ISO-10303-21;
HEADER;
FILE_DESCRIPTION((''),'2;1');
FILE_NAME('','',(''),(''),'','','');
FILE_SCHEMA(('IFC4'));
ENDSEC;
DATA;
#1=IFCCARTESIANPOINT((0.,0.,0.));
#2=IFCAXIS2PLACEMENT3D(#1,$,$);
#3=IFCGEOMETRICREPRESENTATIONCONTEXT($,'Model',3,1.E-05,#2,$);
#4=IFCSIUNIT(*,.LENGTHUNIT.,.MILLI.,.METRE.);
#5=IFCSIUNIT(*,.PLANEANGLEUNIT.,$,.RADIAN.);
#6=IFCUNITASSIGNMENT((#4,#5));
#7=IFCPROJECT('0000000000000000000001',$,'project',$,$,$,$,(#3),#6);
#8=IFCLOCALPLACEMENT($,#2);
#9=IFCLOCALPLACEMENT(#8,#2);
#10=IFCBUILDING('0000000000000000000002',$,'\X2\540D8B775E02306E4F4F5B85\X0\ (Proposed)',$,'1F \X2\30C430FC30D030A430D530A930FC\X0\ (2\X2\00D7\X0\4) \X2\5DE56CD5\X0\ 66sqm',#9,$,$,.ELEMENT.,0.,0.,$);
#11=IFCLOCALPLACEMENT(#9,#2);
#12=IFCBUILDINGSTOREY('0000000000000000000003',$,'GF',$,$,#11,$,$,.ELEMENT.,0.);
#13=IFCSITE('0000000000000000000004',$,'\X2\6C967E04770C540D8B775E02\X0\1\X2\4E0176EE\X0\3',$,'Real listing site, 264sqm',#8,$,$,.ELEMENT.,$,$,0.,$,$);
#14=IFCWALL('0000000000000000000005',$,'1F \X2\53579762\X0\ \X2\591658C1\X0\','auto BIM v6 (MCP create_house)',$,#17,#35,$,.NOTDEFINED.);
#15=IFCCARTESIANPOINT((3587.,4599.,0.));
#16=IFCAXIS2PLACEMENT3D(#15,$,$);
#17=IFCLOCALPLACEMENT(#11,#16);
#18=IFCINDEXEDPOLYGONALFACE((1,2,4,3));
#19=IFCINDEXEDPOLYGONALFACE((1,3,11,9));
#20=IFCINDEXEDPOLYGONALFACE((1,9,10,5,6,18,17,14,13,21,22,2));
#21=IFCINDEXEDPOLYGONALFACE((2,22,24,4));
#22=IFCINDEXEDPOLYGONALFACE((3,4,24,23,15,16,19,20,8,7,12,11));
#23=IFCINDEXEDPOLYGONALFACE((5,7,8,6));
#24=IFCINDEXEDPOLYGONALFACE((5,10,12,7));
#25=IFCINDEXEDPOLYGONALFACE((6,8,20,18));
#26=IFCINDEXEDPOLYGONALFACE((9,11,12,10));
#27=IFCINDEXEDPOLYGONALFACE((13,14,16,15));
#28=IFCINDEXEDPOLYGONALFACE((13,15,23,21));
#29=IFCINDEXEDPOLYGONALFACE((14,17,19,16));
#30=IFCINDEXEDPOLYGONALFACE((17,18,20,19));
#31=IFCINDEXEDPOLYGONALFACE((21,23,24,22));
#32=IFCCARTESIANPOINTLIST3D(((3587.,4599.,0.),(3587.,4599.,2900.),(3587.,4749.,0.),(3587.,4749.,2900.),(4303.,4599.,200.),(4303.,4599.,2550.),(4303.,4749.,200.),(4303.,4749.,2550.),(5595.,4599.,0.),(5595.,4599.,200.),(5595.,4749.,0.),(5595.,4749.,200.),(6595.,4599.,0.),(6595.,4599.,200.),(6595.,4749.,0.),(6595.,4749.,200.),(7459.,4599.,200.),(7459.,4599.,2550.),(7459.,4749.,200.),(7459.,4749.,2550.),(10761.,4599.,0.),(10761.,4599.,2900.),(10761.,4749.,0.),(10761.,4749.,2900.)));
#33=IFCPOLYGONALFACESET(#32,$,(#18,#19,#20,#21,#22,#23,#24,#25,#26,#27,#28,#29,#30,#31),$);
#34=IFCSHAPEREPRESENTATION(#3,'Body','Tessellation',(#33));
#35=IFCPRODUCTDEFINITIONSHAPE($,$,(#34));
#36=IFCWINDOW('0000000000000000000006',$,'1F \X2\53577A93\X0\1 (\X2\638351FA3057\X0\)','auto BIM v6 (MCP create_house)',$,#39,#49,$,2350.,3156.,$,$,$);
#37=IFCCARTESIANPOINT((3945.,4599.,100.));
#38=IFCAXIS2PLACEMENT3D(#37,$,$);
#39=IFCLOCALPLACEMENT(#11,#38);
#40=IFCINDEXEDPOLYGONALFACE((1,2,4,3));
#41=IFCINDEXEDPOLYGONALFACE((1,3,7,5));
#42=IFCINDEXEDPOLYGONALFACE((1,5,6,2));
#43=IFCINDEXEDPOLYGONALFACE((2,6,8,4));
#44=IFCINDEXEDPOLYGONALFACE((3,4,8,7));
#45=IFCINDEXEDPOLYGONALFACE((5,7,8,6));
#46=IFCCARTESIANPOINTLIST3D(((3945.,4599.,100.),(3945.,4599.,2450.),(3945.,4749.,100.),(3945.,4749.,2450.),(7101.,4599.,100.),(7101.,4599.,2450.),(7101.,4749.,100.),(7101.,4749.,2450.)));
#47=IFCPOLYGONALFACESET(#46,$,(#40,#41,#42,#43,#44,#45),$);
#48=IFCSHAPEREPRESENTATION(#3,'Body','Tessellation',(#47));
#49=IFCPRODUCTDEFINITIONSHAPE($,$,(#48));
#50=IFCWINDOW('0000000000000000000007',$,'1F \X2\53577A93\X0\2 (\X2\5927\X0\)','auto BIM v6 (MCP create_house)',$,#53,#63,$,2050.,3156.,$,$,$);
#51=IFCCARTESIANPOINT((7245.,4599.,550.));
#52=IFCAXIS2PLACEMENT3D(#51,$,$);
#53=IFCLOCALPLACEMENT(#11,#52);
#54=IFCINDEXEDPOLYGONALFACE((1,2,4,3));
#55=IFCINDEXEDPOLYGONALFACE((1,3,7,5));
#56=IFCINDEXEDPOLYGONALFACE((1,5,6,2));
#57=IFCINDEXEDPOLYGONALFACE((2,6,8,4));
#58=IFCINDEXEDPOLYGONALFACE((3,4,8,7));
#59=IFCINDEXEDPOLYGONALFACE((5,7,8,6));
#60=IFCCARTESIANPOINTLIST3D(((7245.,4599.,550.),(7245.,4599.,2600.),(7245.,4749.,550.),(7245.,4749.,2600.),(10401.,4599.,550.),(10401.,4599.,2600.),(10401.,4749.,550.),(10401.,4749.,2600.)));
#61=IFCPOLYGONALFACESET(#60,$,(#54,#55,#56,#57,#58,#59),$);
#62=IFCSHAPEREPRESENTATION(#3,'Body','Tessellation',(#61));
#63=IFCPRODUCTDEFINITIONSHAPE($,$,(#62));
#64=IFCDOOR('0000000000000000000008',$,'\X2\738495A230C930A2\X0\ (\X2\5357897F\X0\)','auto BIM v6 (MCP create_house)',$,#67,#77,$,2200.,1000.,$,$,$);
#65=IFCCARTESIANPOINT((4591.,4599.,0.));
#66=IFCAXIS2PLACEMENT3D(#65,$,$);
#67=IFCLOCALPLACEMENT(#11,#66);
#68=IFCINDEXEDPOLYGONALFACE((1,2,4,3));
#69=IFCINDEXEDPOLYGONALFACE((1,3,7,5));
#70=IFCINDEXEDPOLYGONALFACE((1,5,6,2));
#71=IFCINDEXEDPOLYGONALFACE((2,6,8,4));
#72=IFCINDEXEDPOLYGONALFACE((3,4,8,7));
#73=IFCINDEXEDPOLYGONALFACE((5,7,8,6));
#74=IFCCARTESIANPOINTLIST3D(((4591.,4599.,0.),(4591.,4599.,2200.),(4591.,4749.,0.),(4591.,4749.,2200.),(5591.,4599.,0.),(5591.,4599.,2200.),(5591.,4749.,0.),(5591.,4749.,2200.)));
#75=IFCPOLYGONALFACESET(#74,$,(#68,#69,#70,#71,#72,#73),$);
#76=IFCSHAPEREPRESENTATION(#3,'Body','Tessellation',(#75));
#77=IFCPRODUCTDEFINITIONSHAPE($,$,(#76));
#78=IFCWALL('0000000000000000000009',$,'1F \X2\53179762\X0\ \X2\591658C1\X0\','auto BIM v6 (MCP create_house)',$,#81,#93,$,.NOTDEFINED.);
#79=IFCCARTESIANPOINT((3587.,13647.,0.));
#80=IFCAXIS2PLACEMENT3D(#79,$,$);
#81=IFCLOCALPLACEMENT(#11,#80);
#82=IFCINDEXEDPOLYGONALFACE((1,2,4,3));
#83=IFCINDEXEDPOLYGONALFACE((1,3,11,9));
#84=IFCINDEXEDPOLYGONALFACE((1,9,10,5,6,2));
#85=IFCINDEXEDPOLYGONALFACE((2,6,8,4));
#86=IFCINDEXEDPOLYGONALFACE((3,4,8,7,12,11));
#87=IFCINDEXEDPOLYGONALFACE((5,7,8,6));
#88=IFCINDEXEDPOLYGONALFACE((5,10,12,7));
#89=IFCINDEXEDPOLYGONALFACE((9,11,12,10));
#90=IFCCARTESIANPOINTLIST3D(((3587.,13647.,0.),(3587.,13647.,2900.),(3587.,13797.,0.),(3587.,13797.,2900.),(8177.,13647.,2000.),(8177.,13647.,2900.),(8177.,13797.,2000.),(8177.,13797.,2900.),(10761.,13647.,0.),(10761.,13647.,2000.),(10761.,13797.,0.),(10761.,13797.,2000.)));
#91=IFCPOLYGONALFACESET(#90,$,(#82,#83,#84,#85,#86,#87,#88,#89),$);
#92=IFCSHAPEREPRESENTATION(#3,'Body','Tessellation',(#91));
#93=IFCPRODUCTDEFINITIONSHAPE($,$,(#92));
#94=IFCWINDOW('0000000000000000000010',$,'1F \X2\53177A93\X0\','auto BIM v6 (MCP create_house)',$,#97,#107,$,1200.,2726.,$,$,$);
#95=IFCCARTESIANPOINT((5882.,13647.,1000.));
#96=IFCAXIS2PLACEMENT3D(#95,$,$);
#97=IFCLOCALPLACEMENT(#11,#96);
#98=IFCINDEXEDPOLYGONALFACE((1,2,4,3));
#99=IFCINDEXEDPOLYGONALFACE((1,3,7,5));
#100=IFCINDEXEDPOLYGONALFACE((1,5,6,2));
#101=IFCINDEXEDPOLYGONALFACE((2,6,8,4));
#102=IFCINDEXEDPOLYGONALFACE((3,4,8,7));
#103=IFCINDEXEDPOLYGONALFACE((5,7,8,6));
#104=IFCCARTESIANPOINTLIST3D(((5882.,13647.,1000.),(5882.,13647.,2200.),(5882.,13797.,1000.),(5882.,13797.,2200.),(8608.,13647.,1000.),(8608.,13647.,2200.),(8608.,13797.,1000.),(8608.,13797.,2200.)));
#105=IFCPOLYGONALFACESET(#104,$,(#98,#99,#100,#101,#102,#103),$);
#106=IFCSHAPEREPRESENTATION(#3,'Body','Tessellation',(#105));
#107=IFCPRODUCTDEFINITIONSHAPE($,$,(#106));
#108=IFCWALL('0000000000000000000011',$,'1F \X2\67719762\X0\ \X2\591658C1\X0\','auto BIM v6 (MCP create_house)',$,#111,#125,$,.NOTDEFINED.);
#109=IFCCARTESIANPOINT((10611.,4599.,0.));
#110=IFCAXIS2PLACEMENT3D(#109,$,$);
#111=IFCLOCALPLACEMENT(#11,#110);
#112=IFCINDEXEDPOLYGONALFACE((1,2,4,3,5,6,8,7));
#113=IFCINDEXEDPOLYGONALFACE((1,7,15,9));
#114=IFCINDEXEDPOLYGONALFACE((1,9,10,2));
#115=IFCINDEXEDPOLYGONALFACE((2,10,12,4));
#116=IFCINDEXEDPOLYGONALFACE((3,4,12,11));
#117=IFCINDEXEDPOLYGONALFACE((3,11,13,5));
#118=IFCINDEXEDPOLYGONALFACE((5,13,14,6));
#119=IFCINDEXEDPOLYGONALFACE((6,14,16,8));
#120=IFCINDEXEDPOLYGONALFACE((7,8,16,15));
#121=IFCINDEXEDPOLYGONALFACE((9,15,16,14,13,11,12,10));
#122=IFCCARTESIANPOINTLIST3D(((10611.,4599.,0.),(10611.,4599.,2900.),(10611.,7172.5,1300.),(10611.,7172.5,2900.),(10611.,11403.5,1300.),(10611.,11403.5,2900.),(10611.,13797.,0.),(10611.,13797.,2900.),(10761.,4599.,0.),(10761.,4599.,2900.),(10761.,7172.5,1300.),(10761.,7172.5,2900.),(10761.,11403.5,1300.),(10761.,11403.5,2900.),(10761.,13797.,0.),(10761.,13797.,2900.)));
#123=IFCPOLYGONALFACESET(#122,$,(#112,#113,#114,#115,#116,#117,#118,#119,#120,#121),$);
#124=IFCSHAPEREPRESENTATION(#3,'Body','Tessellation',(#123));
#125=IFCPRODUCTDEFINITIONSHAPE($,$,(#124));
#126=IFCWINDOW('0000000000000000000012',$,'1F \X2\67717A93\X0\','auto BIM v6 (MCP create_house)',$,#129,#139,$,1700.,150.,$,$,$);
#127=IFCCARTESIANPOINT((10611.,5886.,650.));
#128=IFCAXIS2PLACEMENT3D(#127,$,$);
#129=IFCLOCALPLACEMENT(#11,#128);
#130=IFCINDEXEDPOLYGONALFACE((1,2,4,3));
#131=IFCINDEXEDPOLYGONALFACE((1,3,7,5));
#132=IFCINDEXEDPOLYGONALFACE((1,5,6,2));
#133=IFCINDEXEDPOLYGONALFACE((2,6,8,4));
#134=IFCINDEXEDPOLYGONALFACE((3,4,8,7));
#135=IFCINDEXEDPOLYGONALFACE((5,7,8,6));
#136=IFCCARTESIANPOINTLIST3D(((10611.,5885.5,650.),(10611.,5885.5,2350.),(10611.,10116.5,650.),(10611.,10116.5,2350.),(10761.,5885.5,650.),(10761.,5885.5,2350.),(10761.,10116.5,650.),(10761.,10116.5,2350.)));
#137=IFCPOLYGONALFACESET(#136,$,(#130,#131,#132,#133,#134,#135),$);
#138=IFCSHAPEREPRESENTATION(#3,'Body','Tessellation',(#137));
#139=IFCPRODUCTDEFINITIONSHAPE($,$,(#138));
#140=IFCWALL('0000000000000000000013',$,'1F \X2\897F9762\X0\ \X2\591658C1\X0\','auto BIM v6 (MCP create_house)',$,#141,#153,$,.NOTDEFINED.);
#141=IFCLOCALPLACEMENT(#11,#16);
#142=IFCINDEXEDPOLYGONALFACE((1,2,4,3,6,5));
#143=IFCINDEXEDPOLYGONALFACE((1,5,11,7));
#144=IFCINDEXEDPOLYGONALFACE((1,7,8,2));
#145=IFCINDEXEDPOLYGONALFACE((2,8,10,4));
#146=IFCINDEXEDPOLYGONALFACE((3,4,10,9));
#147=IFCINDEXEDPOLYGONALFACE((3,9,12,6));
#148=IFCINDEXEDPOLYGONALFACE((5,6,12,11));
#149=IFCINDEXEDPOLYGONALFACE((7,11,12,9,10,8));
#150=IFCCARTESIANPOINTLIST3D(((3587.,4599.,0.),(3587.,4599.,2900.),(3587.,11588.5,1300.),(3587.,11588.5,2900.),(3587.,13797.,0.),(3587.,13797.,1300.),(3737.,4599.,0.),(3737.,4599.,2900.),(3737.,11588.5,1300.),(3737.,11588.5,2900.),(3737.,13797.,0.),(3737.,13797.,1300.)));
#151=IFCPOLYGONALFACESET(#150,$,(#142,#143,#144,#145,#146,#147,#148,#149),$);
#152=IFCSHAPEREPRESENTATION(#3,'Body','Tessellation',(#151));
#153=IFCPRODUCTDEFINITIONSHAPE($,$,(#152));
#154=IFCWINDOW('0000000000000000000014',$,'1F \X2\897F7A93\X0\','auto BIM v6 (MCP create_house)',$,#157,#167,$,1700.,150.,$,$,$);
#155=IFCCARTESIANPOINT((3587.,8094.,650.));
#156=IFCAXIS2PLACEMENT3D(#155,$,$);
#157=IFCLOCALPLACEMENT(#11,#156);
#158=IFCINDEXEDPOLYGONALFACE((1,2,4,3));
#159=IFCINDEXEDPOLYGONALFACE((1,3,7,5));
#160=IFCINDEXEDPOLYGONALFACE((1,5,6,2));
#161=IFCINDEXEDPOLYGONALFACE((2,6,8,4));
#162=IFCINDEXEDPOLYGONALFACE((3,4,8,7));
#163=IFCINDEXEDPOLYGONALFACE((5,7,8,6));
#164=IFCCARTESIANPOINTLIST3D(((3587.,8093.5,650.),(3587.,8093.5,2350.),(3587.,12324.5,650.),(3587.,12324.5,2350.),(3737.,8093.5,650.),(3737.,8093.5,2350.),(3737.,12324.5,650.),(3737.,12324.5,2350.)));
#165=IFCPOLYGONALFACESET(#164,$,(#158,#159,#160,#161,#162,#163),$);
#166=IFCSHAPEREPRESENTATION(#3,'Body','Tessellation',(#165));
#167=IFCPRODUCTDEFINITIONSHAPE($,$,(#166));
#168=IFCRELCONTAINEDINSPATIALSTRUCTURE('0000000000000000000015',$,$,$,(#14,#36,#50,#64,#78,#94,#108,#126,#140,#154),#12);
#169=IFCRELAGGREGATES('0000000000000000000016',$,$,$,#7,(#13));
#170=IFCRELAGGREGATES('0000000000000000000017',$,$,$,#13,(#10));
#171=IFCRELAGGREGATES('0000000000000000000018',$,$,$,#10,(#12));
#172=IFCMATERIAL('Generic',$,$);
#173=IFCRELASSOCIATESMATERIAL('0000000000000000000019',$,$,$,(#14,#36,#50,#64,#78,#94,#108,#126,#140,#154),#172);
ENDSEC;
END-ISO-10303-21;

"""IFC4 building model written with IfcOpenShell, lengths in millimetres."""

from ifc_helpers import new_model, si_unit, frame, frame_2d, origin, place, context, project, spatial, rectangle, extrude, material, element, fill, save


model = new_model("IFC4")

# Units and contexts
model_context = context("Model", 3, precision=1e-05, world=origin())
ifc_project = project(units=[si_unit("LENGTHUNIT", "METRE", prefix="MILLI"), si_unit("PLANEANGLEUNIT", "RADIAN")], contexts=[model_context])

# Site, building, storey
site_placement = place(None, origin())
site = spatial("IfcSite", under=ifc_project, at=site_placement, Name="沖縄県名護市1丁目3", ObjectType="Real listing site, 264sqm", CompositionType="ELEMENT", RefElevation=0.0)
building_placement = place(site_placement, origin())
building = spatial("IfcBuilding", under=site, at=building_placement, Name="名護市の住宅 (Proposed)", ObjectType="1F ツーバイフォー (2×4) 工法 66sqm", CompositionType="ELEMENT", ElevationOfRefHeight=0.0, ElevationOfTerrain=0.0)
storey_placement = place(building_placement, origin())
storey = spatial("IfcBuildingStorey", under=building, at=storey_placement, Name="GF", CompositionType="ELEMENT", Elevation=0.0)

# Shared definitions
ifc_material = material(Name="Generic")

# Wall, openings, windows, door
wall_1_placement = place(storey_placement, frame((3587.0, 4599.0, 0.0)))
wall_1 = element("IfcWall", 1, at=wall_1_placement, inside=storey, material=ifc_material, Name="1F 南面 外壁", Description="auto BIM v6 (MCP create_house)", PredefinedType="NOTDEFINED", context=model_context, shape_type="SweptSolid", body=[
    extrude(rectangle(XDim=7174.0, YDim=150.0, at=frame_2d((3587.0, 75.0))), frame((3587.0, 4599.0, 0.0)), (0.0, 0.0, 1.0), 2900.0),
])
opening_1_placement = place(storey_placement, frame((3945.0, 4599.0, 100.0)))
opening_1 = element("IfcOpeningElement", 2, at=opening_1_placement, cuts=wall_1, PredefinedType="NOTDEFINED", context=model_context, shape_type="SweptSolid", body=[
    extrude(rectangle(XDim=3156.0, YDim=150.0, at=frame_2d((1578.0, 75.0))), frame((3945.0, 4599.0, 100.0)), (0.0, 0.0, 1.0), 2350.0),
])
opening_2_placement = place(storey_placement, frame((7245.0, 4599.0, 550.0)))
opening_2 = element("IfcOpeningElement", 3, at=opening_2_placement, cuts=wall_1, PredefinedType="NOTDEFINED", context=model_context, shape_type="SweptSolid", body=[
    extrude(rectangle(XDim=3156.0, YDim=150.0, at=frame_2d((1578.0, 75.0))), frame((7245.0, 4599.0, 550.0)), (0.0, 0.0, 1.0), 2050.0),
])
opening_3_placement = place(storey_placement, frame((4591.0, 4599.0, 0.0)))
opening_3 = element("IfcOpeningElement", 4, at=opening_3_placement, cuts=wall_1, PredefinedType="NOTDEFINED", context=model_context, shape_type="SweptSolid", body=[
    extrude(rectangle(XDim=1000.0, YDim=150.0, at=frame_2d((500.0, 75.0))), frame((4591.0, 4599.0, 0.0)), (0.0, 0.0, 1.0), 2200.0),
])
window_1_placement = place(storey_placement, frame((3945.0, 4599.0, 100.0)))
window_1 = element("IfcWindow", 5, at=window_1_placement, inside=storey, material=ifc_material, Name="1F 南窓1 (掃出し)", Description="auto BIM v6 (MCP create_house)", OverallHeight=2350.0, OverallWidth=3156.0, context=model_context, shape_type="SweptSolid", body=[
    extrude(rectangle(XDim=3156.0, YDim=150.0, at=frame_2d((1578.0, 75.0))), frame((3945.0, 4599.0, 100.0)), (0.0, 0.0, 1.0), 2350.0),
])
fill(opening_1, window_1)
window_2_placement = place(storey_placement, frame((7245.0, 4599.0, 550.0)))
window_2 = element("IfcWindow", 6, at=window_2_placement, inside=storey, material=ifc_material, Name="1F 南窓2 (大)", Description="auto BIM v6 (MCP create_house)", OverallHeight=2050.0, OverallWidth=3156.0, context=model_context, shape_type="SweptSolid", body=[
    extrude(rectangle(XDim=3156.0, YDim=150.0, at=frame_2d((1578.0, 75.0))), frame((7245.0, 4599.0, 550.0)), (0.0, 0.0, 1.0), 2050.0),
])
fill(opening_2, window_2)
door_placement = place(storey_placement, frame((4591.0, 4599.0, 0.0)))
door = element("IfcDoor", 7, at=door_placement, inside=storey, material=ifc_material, Name="玄関ドア (南西)", Description="auto BIM v6 (MCP create_house)", OverallHeight=2200.0, OverallWidth=1000.0, context=model_context, shape_type="SweptSolid", body=[
    extrude(rectangle(XDim=1000.0, YDim=150.0, at=frame_2d((500.0, 75.0))), frame((4591.0, 4599.0, 0.0)), (0.0, 0.0, 1.0), 2200.0),
])
fill(opening_3, door)

# Walls, openings, windows
wall_2_placement = place(storey_placement, frame((3587.0, 13647.0, 0.0)))
wall_2 = element("IfcWall", 8, at=wall_2_placement, inside=storey, material=ifc_material, Name="1F 北面 外壁", Description="auto BIM v6 (MCP create_house)", PredefinedType="NOTDEFINED", context=model_context, shape_type="SweptSolid", body=[
    extrude(rectangle(XDim=7174.0, YDim=150.0, at=frame_2d((3587.0, 75.0))), frame((3587.0, 13647.0, 0.0)), (0.0, 0.0, 1.0), 2900.0),
])
opening_4_placement = place(storey_placement, frame((5882.0, 13647.0, 1000.0)))
opening_4 = element("IfcOpeningElement", 9, at=opening_4_placement, cuts=wall_2, PredefinedType="NOTDEFINED", context=model_context, shape_type="SweptSolid", body=[
    extrude(rectangle(XDim=2726.0, YDim=150.0, at=frame_2d((1363.0, 75.0))), frame((5882.0, 13647.0, 1000.0)), (0.0, 0.0, 1.0), 1200.0),
])
window_3_placement = place(storey_placement, frame((5882.0, 13647.0, 1000.0)))
window_3 = element("IfcWindow", 10, at=window_3_placement, inside=storey, material=ifc_material, Name="1F 北窓", Description="auto BIM v6 (MCP create_house)", OverallHeight=1200.0, OverallWidth=2726.0, context=model_context, shape_type="SweptSolid", body=[
    extrude(rectangle(XDim=2726.0, YDim=150.0, at=frame_2d((1363.0, 75.0))), frame((5882.0, 13647.0, 1000.0)), (0.0, 0.0, 1.0), 1200.0),
])
fill(opening_4, window_3)
wall_3_placement = place(storey_placement, frame((10611.0, 4599.0, 0.0)))
wall_3 = element("IfcWall", 11, at=wall_3_placement, inside=storey, material=ifc_material, Name="1F 東面 外壁", Description="auto BIM v6 (MCP create_house)", PredefinedType="NOTDEFINED", context=model_context, shape_type="SweptSolid", body=[
    extrude(rectangle(XDim=150.0, YDim=9198.0, at=frame_2d((75.0, 4599.0))), frame((10611.0, 4599.0, 0.0)), (0.0, 0.0, 1.0), 2900.0),
])
opening_5_placement = place(storey_placement, frame((10611.0, 5886.0, 650.0)))
opening_5 = element("IfcOpeningElement", 12, at=opening_5_placement, cuts=wall_3, PredefinedType="NOTDEFINED", context=model_context, shape_type="SweptSolid", body=[
    extrude(rectangle(XDim=150.0, YDim=4231.0, at=frame_2d((75.0, 2115.0))), frame((10611.0, 5886.0, 650.0)), (0.0, 0.0, 1.0), 1700.0),
])
window_4_placement = place(storey_placement, frame((10611.0, 5886.0, 650.0)))
window_4 = element("IfcWindow", 13, at=window_4_placement, inside=storey, material=ifc_material, Name="1F 東窓", Description="auto BIM v6 (MCP create_house)", OverallHeight=1700.0, OverallWidth=150.0, context=model_context, shape_type="SweptSolid", body=[
    extrude(rectangle(XDim=150.0, YDim=4231.0, at=frame_2d((75.0, 2115.0))), frame((10611.0, 5886.0, 650.0)), (0.0, 0.0, 1.0), 1700.0),
])
fill(opening_5, window_4)
wall_4_placement = place(storey_placement, frame((3587.0, 4599.0, 0.0)))
wall_4 = element("IfcWall", 14, at=wall_4_placement, inside=storey, material=ifc_material, Name="1F 西面 外壁", Description="auto BIM v6 (MCP create_house)", PredefinedType="NOTDEFINED", context=model_context, shape_type="SweptSolid", body=[
    extrude(rectangle(XDim=150.0, YDim=9198.0, at=frame_2d((75.0, 4599.0))), frame((3587.0, 4599.0, 0.0)), (0.0, 0.0, 1.0), 2900.0),
])
opening_6_placement = place(storey_placement, frame((3587.0, 8094.0, 650.0)))
opening_6 = element("IfcOpeningElement", 15, at=opening_6_placement, cuts=wall_4, PredefinedType="NOTDEFINED", context=model_context, shape_type="SweptSolid", body=[
    extrude(rectangle(XDim=150.0, YDim=4231.0, at=frame_2d((75.0, 2115.0))), frame((3587.0, 8094.0, 650.0)), (0.0, 0.0, 1.0), 1700.0),
])
window_5_placement = place(storey_placement, frame((3587.0, 8094.0, 650.0)))
window_5 = element("IfcWindow", 16, at=window_5_placement, inside=storey, material=ifc_material, Name="1F 西窓", Description="auto BIM v6 (MCP create_house)", OverallHeight=1700.0, OverallWidth=150.0, context=model_context, shape_type="SweptSolid", body=[
    extrude(rectangle(XDim=150.0, YDim=4231.0, at=frame_2d((75.0, 2115.0))), frame((3587.0, 8094.0, 650.0)), (0.0, 0.0, 1.0), 1700.0),
])
fill(opening_6, window_5)

save(model, "model.ifc")
